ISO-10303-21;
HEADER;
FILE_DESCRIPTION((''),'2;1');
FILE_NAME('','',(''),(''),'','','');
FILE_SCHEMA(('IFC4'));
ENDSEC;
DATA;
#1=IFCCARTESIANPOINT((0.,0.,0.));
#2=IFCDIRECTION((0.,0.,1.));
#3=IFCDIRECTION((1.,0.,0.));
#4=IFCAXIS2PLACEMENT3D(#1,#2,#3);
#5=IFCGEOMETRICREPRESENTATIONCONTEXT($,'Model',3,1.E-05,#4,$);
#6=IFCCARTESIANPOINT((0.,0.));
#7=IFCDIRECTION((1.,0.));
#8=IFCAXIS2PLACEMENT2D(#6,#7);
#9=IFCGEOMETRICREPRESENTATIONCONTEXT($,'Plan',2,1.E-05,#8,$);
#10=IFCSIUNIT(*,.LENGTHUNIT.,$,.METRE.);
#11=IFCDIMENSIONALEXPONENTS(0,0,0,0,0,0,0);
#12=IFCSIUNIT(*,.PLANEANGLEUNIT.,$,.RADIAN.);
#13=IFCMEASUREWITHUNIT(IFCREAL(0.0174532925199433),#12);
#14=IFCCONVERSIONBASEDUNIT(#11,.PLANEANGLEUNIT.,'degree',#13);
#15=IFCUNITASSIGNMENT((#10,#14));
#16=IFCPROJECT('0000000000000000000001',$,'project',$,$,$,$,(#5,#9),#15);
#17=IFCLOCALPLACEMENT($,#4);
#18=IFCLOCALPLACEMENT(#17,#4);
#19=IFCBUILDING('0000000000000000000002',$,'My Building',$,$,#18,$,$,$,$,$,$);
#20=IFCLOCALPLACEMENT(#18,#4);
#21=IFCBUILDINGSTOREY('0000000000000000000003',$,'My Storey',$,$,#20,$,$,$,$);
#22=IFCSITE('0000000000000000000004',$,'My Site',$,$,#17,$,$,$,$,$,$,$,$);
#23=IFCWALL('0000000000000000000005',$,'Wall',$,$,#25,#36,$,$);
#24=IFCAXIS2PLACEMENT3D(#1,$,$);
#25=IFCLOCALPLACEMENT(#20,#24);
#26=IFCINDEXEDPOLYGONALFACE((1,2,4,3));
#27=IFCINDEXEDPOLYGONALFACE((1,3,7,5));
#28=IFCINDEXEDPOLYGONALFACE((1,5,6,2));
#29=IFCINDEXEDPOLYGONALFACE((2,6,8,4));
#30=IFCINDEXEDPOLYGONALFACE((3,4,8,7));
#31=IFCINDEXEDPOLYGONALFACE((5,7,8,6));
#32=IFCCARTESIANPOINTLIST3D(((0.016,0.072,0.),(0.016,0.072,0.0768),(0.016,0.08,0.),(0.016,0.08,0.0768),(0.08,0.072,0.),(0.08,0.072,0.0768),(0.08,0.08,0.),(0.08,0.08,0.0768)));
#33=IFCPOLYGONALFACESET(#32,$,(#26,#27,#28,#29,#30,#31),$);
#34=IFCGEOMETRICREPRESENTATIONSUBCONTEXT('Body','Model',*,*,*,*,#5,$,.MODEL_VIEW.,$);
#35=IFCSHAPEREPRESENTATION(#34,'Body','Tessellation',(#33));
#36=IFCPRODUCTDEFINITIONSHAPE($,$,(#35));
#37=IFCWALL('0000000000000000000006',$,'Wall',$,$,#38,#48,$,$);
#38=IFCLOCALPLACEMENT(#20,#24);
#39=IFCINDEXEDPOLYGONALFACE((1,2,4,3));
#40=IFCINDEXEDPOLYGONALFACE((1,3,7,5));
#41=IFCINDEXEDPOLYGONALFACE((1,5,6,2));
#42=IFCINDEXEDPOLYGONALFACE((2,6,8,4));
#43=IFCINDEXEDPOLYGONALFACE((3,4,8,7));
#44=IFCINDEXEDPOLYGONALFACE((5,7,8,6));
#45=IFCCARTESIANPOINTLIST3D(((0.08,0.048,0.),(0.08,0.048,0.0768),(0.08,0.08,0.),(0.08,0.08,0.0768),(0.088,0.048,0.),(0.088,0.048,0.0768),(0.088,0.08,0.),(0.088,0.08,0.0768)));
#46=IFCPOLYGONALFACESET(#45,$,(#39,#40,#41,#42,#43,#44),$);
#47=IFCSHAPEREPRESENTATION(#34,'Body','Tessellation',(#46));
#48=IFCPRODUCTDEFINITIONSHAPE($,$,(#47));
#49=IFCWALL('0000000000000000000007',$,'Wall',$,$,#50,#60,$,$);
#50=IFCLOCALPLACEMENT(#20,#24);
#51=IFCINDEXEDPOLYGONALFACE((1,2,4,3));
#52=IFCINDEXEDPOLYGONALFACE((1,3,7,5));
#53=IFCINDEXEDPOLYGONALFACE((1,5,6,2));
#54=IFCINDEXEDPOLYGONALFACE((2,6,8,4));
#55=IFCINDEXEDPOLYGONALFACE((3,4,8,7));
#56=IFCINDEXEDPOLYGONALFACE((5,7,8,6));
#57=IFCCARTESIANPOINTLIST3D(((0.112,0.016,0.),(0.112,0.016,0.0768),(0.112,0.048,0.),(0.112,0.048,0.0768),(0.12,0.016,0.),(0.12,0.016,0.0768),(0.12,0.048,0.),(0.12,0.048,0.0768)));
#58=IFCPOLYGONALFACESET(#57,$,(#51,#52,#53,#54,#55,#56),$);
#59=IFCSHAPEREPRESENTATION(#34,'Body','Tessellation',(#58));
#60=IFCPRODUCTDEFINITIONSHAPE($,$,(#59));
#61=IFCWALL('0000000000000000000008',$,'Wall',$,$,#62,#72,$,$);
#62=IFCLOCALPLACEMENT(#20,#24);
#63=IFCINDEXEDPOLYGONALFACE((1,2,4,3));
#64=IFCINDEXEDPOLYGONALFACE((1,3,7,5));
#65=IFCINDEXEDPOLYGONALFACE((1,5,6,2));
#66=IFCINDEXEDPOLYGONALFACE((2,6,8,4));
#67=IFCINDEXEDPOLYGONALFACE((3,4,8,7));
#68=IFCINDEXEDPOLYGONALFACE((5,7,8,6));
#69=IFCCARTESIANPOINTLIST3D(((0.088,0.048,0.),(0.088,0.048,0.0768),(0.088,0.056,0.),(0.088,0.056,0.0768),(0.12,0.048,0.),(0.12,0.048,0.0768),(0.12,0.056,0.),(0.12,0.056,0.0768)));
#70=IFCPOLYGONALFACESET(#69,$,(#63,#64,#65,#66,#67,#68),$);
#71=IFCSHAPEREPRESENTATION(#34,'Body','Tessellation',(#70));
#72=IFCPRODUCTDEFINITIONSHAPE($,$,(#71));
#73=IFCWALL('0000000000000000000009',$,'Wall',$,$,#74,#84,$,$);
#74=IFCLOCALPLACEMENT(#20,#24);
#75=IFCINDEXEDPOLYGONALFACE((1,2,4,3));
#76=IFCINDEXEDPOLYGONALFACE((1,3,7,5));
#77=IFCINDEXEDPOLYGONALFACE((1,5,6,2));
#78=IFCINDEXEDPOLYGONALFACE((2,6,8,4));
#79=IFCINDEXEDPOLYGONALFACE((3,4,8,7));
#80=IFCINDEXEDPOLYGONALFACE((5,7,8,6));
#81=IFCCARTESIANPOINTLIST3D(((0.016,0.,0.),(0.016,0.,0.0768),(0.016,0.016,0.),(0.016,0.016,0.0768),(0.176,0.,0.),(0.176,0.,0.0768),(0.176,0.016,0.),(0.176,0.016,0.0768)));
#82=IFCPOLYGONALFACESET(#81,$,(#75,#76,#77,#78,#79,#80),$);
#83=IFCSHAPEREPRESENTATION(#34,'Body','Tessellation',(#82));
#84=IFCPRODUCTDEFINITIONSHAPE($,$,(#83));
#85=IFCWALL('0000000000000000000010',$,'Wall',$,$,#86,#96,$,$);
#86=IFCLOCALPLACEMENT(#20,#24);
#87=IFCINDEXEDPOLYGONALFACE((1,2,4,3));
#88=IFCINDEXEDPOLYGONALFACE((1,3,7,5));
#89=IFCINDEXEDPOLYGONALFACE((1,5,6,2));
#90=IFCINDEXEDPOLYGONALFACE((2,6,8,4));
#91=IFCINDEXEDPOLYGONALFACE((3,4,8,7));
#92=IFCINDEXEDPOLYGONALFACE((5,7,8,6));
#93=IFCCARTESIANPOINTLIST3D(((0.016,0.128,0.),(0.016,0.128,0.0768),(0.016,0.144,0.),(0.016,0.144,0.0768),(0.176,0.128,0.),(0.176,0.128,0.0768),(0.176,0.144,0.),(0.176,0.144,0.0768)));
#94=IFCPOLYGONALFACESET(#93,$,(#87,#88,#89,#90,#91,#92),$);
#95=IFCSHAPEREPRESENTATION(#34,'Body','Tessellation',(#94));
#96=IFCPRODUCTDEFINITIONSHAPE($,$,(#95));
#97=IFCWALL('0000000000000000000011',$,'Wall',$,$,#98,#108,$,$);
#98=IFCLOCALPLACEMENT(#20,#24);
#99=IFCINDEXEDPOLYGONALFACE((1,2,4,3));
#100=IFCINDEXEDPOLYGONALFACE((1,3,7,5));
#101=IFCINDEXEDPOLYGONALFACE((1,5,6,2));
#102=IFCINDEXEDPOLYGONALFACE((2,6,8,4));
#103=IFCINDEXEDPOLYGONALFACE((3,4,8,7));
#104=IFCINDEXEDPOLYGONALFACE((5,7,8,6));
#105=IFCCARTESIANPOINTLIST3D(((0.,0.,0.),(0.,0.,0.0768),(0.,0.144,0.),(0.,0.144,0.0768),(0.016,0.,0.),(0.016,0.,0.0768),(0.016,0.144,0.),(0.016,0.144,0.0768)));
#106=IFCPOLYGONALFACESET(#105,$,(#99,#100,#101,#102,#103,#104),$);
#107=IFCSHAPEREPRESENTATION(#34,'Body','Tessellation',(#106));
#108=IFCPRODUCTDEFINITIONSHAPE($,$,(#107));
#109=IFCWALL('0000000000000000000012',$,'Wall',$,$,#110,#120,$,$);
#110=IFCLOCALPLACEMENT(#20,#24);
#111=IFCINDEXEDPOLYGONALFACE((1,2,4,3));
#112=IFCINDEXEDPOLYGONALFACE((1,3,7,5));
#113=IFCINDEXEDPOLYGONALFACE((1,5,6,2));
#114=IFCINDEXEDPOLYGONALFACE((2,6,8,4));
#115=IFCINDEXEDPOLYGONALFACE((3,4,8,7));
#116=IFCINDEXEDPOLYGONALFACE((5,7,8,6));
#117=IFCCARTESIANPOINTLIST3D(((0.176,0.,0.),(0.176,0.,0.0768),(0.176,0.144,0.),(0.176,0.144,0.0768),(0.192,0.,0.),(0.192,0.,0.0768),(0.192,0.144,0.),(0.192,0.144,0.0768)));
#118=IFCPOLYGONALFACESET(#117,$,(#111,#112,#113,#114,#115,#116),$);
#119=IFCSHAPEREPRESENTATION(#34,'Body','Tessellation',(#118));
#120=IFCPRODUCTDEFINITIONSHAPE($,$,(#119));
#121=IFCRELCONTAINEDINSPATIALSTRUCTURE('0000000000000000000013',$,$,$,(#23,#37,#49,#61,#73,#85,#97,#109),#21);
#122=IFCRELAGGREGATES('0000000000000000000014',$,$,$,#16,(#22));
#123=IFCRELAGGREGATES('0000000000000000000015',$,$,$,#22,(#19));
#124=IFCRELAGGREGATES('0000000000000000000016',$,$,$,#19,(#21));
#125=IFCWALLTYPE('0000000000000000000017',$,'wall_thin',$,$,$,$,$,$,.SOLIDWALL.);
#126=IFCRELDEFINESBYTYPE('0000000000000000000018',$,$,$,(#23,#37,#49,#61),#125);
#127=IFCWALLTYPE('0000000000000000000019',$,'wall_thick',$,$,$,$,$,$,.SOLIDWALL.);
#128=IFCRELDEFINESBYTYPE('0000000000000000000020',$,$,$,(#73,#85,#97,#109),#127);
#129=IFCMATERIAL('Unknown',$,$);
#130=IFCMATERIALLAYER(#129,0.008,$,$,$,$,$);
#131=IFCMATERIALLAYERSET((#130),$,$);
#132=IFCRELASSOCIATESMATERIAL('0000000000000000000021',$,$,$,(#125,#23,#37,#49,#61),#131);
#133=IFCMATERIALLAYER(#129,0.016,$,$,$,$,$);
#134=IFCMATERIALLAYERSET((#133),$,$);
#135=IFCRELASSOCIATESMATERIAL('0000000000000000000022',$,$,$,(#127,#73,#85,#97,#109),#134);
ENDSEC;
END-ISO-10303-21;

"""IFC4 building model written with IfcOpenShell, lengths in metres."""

from ifc_helpers import new_model, entity, si_unit, converted_unit, frame, origin_with_axes, origin_2d_with_axis, place, context, subcontext, project, spatial, indexed_curve, outline, extrude, material, layer, layer_set, layer_usage, type_object, element, save


model = new_model("IFC4")

# Units and contexts
model_context = context("Model", 3, precision=1e-05, world=origin_with_axes())
plan_context = context("Plan", 2, precision=1e-05, world=origin_2d_with_axis())
body_context = subcontext(model_context, "Body", "Model", "MODEL_VIEW")
ifc_project = project(units=[si_unit("LENGTHUNIT", "METRE"), converted_unit("PLANEANGLEUNIT", "degree", entity("IfcReal", 0.0174532925199433), si_unit("PLANEANGLEUNIT", "RADIAN"), dimensions=[0, 0, 0, 0, 0, 0, 0])], contexts=[model_context, plan_context])

# Site, building, storey
site_placement = place(None, origin_with_axes())
site = spatial("IfcSite", under=ifc_project, at=site_placement, Name="My Site")
building_placement = place(site_placement, origin_with_axes())
building = spatial("IfcBuilding", under=site, at=building_placement, Name="My Building")
storey_placement = place(building_placement, origin_with_axes())
storey = spatial("IfcBuildingStorey", under=building, at=storey_placement, Name="My Storey")

# Walls
ifc_material = material(Name="Unknown")
ifc_layer_1 = layer(ifc_material, 0.008)
ifc_layer_set_1 = layer_set([ifc_layer_1])
ifc_layer_usage_1 = layer_usage(ifc_layer_set_1, "AXIS2", "POSITIVE", 0.0)
wall_type_1 = type_object("IfcWallType", Name="wall_thin", PredefinedType="SOLIDWALL", material=ifc_layer_set_1)
wall_1_placement = place(storey_placement, frame((0.016, 0.072, 0.0), z_axis=(0.0, 0.0, 1.0), x_axis=(1.0, 0.0, 0.0)))
element("IfcWall", 1, at=wall_1_placement, inside=storey, type_object=wall_type_1, material=ifc_layer_usage_1, Name="Wall", context=body_context, shape_type="SweptSolid", body=[
    extrude(outline(indexed_curve([(0.0, 0.0), (0.0, 0.008), (0.064, 0.008), (0.064, 0.0), (0.0, 0.0)], self_intersect=False)), origin_with_axes(), (0.0, 0.0, 1.0), 0.0768),
])
ifc_layer_usage_2 = layer_usage(ifc_layer_set_1, "AXIS2", "POSITIVE", 0.0)
wall_2_placement = place(storey_placement, frame((0.08, 0.08, 0.0), z_axis=(0.0, 0.0, 1.0), x_axis=(0.0, -1.0, 0.0)))
element("IfcWall", 2, at=wall_2_placement, inside=storey, type_object=wall_type_1, material=ifc_layer_usage_2, Name="Wall", context=body_context, shape_type="SweptSolid", body=[
    extrude(outline(indexed_curve([(0.0, 0.0), (0.0, 0.008), (0.032, 0.008), (0.032, 0.0), (0.0, 0.0)], self_intersect=False)), origin_with_axes(), (0.0, 0.0, 1.0), 0.0768),
])
ifc_layer_usage_3 = layer_usage(ifc_layer_set_1, "AXIS2", "POSITIVE", 0.0)
wall_3_placement = place(storey_placement, frame((0.112, 0.048, 0.0), z_axis=(0.0, 0.0, 1.0), x_axis=(0.0, -1.0, 0.0)))
element("IfcWall", 3, at=wall_3_placement, inside=storey, type_object=wall_type_1, material=ifc_layer_usage_3, Name="Wall", context=body_context, shape_type="SweptSolid", body=[
    extrude(outline(indexed_curve([(0.0, 0.0), (0.0, 0.008), (0.032, 0.008), (0.032, 0.0), (0.0, 0.0)], self_intersect=False)), origin_with_axes(), (0.0, 0.0, 1.0), 0.0768),
])
ifc_layer_usage_4 = layer_usage(ifc_layer_set_1, "AXIS2", "POSITIVE", 0.0)
wall_4_placement = place(storey_placement, frame((0.088, 0.048, 0.0), z_axis=(0.0, 0.0, 1.0), x_axis=(1.0, 0.0, 0.0)))
element("IfcWall", 4, at=wall_4_placement, inside=storey, type_object=wall_type_1, material=ifc_layer_usage_4, Name="Wall", context=body_context, shape_type="SweptSolid", body=[
    extrude(outline(indexed_curve([(0.0, 0.0), (0.0, 0.008), (0.032, 0.008), (0.032, 0.0), (0.0, 0.0)], self_intersect=False)), origin_with_axes(), (0.0, 0.0, 1.0), 0.0768),
])
ifc_layer_2 = layer(ifc_material, 0.016)
ifc_layer_set_2 = layer_set([ifc_layer_2])
ifc_layer_usage_5 = layer_usage(ifc_layer_set_2, "AXIS2", "POSITIVE", 0.0)
wall_type_2 = type_object("IfcWallType", Name="wall_thick", PredefinedType="SOLIDWALL", material=ifc_layer_set_2)
wall_5_placement = place(storey_placement, frame((0.016, 0.0, 0.0), z_axis=(0.0, 0.0, 1.0), x_axis=(1.0, 0.0, 0.0)))
element("IfcWall", 5, at=wall_5_placement, inside=storey, type_object=wall_type_2, material=ifc_layer_usage_5, Name="Wall", context=body_context, shape_type="SweptSolid", body=[
    extrude(outline(indexed_curve([(0.0, 0.0), (0.0, 0.016), (0.16, 0.016), (0.16, 0.0), (0.0, 0.0)], self_intersect=False)), origin_with_axes(), (0.0, 0.0, 1.0), 0.0768),
])
ifc_layer_usage_6 = layer_usage(ifc_layer_set_2, "AXIS2", "POSITIVE", 0.0)
wall_6_placement = place(storey_placement, frame((0.016, 0.128, 0.0), z_axis=(0.0, 0.0, 1.0), x_axis=(1.0, 0.0, 0.0)))
element("IfcWall", 6, at=wall_6_placement, inside=storey, type_object=wall_type_2, material=ifc_layer_usage_6, Name="Wall", context=body_context, shape_type="SweptSolid", body=[
    extrude(outline(indexed_curve([(0.0, 0.0), (0.0, 0.016), (0.16, 0.016), (0.16, 0.0), (0.0, 0.0)], self_intersect=False)), origin_with_axes(), (0.0, 0.0, 1.0), 0.0768),
])
ifc_layer_usage_7 = layer_usage(ifc_layer_set_2, "AXIS2", "POSITIVE", 0.0)
wall_7_placement = place(storey_placement, frame((0.016, 0.0, 0.0), z_axis=(0.0, 0.0, 1.0), x_axis=(0.0, 1.0, 0.0)))
element("IfcWall", 7, at=wall_7_placement, inside=storey, type_object=wall_type_2, material=ifc_layer_usage_7, Name="Wall", context=body_context, shape_type="SweptSolid", body=[
    extrude(outline(indexed_curve([(0.0, 0.0), (0.0, 0.016), (0.144, 0.016), (0.144, 0.0), (0.0, 0.0)], self_intersect=False)), origin_with_axes(), (0.0, 0.0, 1.0), 0.0768),
])
ifc_layer_usage_8 = layer_usage(ifc_layer_set_2, "AXIS2", "POSITIVE", 0.0)
wall_8_placement = place(storey_placement, frame((0.176, 0.144, 0.0), z_axis=(0.0, 0.0, 1.0), x_axis=(0.0, -1.0, 0.0)))
element("IfcWall", 8, at=wall_8_placement, inside=storey, type_object=wall_type_2, material=ifc_layer_usage_8, Name="Wall", context=body_context, shape_type="SweptSolid", body=[
    extrude(outline(indexed_curve([(0.0, 0.0), (0.0, 0.016), (0.144, 0.016), (0.144, 0.0), (0.0, 0.0)], self_intersect=False)), origin_with_axes(), (0.0, 0.0, 1.0), 0.0768),
])

save(model, "model.ifc")
